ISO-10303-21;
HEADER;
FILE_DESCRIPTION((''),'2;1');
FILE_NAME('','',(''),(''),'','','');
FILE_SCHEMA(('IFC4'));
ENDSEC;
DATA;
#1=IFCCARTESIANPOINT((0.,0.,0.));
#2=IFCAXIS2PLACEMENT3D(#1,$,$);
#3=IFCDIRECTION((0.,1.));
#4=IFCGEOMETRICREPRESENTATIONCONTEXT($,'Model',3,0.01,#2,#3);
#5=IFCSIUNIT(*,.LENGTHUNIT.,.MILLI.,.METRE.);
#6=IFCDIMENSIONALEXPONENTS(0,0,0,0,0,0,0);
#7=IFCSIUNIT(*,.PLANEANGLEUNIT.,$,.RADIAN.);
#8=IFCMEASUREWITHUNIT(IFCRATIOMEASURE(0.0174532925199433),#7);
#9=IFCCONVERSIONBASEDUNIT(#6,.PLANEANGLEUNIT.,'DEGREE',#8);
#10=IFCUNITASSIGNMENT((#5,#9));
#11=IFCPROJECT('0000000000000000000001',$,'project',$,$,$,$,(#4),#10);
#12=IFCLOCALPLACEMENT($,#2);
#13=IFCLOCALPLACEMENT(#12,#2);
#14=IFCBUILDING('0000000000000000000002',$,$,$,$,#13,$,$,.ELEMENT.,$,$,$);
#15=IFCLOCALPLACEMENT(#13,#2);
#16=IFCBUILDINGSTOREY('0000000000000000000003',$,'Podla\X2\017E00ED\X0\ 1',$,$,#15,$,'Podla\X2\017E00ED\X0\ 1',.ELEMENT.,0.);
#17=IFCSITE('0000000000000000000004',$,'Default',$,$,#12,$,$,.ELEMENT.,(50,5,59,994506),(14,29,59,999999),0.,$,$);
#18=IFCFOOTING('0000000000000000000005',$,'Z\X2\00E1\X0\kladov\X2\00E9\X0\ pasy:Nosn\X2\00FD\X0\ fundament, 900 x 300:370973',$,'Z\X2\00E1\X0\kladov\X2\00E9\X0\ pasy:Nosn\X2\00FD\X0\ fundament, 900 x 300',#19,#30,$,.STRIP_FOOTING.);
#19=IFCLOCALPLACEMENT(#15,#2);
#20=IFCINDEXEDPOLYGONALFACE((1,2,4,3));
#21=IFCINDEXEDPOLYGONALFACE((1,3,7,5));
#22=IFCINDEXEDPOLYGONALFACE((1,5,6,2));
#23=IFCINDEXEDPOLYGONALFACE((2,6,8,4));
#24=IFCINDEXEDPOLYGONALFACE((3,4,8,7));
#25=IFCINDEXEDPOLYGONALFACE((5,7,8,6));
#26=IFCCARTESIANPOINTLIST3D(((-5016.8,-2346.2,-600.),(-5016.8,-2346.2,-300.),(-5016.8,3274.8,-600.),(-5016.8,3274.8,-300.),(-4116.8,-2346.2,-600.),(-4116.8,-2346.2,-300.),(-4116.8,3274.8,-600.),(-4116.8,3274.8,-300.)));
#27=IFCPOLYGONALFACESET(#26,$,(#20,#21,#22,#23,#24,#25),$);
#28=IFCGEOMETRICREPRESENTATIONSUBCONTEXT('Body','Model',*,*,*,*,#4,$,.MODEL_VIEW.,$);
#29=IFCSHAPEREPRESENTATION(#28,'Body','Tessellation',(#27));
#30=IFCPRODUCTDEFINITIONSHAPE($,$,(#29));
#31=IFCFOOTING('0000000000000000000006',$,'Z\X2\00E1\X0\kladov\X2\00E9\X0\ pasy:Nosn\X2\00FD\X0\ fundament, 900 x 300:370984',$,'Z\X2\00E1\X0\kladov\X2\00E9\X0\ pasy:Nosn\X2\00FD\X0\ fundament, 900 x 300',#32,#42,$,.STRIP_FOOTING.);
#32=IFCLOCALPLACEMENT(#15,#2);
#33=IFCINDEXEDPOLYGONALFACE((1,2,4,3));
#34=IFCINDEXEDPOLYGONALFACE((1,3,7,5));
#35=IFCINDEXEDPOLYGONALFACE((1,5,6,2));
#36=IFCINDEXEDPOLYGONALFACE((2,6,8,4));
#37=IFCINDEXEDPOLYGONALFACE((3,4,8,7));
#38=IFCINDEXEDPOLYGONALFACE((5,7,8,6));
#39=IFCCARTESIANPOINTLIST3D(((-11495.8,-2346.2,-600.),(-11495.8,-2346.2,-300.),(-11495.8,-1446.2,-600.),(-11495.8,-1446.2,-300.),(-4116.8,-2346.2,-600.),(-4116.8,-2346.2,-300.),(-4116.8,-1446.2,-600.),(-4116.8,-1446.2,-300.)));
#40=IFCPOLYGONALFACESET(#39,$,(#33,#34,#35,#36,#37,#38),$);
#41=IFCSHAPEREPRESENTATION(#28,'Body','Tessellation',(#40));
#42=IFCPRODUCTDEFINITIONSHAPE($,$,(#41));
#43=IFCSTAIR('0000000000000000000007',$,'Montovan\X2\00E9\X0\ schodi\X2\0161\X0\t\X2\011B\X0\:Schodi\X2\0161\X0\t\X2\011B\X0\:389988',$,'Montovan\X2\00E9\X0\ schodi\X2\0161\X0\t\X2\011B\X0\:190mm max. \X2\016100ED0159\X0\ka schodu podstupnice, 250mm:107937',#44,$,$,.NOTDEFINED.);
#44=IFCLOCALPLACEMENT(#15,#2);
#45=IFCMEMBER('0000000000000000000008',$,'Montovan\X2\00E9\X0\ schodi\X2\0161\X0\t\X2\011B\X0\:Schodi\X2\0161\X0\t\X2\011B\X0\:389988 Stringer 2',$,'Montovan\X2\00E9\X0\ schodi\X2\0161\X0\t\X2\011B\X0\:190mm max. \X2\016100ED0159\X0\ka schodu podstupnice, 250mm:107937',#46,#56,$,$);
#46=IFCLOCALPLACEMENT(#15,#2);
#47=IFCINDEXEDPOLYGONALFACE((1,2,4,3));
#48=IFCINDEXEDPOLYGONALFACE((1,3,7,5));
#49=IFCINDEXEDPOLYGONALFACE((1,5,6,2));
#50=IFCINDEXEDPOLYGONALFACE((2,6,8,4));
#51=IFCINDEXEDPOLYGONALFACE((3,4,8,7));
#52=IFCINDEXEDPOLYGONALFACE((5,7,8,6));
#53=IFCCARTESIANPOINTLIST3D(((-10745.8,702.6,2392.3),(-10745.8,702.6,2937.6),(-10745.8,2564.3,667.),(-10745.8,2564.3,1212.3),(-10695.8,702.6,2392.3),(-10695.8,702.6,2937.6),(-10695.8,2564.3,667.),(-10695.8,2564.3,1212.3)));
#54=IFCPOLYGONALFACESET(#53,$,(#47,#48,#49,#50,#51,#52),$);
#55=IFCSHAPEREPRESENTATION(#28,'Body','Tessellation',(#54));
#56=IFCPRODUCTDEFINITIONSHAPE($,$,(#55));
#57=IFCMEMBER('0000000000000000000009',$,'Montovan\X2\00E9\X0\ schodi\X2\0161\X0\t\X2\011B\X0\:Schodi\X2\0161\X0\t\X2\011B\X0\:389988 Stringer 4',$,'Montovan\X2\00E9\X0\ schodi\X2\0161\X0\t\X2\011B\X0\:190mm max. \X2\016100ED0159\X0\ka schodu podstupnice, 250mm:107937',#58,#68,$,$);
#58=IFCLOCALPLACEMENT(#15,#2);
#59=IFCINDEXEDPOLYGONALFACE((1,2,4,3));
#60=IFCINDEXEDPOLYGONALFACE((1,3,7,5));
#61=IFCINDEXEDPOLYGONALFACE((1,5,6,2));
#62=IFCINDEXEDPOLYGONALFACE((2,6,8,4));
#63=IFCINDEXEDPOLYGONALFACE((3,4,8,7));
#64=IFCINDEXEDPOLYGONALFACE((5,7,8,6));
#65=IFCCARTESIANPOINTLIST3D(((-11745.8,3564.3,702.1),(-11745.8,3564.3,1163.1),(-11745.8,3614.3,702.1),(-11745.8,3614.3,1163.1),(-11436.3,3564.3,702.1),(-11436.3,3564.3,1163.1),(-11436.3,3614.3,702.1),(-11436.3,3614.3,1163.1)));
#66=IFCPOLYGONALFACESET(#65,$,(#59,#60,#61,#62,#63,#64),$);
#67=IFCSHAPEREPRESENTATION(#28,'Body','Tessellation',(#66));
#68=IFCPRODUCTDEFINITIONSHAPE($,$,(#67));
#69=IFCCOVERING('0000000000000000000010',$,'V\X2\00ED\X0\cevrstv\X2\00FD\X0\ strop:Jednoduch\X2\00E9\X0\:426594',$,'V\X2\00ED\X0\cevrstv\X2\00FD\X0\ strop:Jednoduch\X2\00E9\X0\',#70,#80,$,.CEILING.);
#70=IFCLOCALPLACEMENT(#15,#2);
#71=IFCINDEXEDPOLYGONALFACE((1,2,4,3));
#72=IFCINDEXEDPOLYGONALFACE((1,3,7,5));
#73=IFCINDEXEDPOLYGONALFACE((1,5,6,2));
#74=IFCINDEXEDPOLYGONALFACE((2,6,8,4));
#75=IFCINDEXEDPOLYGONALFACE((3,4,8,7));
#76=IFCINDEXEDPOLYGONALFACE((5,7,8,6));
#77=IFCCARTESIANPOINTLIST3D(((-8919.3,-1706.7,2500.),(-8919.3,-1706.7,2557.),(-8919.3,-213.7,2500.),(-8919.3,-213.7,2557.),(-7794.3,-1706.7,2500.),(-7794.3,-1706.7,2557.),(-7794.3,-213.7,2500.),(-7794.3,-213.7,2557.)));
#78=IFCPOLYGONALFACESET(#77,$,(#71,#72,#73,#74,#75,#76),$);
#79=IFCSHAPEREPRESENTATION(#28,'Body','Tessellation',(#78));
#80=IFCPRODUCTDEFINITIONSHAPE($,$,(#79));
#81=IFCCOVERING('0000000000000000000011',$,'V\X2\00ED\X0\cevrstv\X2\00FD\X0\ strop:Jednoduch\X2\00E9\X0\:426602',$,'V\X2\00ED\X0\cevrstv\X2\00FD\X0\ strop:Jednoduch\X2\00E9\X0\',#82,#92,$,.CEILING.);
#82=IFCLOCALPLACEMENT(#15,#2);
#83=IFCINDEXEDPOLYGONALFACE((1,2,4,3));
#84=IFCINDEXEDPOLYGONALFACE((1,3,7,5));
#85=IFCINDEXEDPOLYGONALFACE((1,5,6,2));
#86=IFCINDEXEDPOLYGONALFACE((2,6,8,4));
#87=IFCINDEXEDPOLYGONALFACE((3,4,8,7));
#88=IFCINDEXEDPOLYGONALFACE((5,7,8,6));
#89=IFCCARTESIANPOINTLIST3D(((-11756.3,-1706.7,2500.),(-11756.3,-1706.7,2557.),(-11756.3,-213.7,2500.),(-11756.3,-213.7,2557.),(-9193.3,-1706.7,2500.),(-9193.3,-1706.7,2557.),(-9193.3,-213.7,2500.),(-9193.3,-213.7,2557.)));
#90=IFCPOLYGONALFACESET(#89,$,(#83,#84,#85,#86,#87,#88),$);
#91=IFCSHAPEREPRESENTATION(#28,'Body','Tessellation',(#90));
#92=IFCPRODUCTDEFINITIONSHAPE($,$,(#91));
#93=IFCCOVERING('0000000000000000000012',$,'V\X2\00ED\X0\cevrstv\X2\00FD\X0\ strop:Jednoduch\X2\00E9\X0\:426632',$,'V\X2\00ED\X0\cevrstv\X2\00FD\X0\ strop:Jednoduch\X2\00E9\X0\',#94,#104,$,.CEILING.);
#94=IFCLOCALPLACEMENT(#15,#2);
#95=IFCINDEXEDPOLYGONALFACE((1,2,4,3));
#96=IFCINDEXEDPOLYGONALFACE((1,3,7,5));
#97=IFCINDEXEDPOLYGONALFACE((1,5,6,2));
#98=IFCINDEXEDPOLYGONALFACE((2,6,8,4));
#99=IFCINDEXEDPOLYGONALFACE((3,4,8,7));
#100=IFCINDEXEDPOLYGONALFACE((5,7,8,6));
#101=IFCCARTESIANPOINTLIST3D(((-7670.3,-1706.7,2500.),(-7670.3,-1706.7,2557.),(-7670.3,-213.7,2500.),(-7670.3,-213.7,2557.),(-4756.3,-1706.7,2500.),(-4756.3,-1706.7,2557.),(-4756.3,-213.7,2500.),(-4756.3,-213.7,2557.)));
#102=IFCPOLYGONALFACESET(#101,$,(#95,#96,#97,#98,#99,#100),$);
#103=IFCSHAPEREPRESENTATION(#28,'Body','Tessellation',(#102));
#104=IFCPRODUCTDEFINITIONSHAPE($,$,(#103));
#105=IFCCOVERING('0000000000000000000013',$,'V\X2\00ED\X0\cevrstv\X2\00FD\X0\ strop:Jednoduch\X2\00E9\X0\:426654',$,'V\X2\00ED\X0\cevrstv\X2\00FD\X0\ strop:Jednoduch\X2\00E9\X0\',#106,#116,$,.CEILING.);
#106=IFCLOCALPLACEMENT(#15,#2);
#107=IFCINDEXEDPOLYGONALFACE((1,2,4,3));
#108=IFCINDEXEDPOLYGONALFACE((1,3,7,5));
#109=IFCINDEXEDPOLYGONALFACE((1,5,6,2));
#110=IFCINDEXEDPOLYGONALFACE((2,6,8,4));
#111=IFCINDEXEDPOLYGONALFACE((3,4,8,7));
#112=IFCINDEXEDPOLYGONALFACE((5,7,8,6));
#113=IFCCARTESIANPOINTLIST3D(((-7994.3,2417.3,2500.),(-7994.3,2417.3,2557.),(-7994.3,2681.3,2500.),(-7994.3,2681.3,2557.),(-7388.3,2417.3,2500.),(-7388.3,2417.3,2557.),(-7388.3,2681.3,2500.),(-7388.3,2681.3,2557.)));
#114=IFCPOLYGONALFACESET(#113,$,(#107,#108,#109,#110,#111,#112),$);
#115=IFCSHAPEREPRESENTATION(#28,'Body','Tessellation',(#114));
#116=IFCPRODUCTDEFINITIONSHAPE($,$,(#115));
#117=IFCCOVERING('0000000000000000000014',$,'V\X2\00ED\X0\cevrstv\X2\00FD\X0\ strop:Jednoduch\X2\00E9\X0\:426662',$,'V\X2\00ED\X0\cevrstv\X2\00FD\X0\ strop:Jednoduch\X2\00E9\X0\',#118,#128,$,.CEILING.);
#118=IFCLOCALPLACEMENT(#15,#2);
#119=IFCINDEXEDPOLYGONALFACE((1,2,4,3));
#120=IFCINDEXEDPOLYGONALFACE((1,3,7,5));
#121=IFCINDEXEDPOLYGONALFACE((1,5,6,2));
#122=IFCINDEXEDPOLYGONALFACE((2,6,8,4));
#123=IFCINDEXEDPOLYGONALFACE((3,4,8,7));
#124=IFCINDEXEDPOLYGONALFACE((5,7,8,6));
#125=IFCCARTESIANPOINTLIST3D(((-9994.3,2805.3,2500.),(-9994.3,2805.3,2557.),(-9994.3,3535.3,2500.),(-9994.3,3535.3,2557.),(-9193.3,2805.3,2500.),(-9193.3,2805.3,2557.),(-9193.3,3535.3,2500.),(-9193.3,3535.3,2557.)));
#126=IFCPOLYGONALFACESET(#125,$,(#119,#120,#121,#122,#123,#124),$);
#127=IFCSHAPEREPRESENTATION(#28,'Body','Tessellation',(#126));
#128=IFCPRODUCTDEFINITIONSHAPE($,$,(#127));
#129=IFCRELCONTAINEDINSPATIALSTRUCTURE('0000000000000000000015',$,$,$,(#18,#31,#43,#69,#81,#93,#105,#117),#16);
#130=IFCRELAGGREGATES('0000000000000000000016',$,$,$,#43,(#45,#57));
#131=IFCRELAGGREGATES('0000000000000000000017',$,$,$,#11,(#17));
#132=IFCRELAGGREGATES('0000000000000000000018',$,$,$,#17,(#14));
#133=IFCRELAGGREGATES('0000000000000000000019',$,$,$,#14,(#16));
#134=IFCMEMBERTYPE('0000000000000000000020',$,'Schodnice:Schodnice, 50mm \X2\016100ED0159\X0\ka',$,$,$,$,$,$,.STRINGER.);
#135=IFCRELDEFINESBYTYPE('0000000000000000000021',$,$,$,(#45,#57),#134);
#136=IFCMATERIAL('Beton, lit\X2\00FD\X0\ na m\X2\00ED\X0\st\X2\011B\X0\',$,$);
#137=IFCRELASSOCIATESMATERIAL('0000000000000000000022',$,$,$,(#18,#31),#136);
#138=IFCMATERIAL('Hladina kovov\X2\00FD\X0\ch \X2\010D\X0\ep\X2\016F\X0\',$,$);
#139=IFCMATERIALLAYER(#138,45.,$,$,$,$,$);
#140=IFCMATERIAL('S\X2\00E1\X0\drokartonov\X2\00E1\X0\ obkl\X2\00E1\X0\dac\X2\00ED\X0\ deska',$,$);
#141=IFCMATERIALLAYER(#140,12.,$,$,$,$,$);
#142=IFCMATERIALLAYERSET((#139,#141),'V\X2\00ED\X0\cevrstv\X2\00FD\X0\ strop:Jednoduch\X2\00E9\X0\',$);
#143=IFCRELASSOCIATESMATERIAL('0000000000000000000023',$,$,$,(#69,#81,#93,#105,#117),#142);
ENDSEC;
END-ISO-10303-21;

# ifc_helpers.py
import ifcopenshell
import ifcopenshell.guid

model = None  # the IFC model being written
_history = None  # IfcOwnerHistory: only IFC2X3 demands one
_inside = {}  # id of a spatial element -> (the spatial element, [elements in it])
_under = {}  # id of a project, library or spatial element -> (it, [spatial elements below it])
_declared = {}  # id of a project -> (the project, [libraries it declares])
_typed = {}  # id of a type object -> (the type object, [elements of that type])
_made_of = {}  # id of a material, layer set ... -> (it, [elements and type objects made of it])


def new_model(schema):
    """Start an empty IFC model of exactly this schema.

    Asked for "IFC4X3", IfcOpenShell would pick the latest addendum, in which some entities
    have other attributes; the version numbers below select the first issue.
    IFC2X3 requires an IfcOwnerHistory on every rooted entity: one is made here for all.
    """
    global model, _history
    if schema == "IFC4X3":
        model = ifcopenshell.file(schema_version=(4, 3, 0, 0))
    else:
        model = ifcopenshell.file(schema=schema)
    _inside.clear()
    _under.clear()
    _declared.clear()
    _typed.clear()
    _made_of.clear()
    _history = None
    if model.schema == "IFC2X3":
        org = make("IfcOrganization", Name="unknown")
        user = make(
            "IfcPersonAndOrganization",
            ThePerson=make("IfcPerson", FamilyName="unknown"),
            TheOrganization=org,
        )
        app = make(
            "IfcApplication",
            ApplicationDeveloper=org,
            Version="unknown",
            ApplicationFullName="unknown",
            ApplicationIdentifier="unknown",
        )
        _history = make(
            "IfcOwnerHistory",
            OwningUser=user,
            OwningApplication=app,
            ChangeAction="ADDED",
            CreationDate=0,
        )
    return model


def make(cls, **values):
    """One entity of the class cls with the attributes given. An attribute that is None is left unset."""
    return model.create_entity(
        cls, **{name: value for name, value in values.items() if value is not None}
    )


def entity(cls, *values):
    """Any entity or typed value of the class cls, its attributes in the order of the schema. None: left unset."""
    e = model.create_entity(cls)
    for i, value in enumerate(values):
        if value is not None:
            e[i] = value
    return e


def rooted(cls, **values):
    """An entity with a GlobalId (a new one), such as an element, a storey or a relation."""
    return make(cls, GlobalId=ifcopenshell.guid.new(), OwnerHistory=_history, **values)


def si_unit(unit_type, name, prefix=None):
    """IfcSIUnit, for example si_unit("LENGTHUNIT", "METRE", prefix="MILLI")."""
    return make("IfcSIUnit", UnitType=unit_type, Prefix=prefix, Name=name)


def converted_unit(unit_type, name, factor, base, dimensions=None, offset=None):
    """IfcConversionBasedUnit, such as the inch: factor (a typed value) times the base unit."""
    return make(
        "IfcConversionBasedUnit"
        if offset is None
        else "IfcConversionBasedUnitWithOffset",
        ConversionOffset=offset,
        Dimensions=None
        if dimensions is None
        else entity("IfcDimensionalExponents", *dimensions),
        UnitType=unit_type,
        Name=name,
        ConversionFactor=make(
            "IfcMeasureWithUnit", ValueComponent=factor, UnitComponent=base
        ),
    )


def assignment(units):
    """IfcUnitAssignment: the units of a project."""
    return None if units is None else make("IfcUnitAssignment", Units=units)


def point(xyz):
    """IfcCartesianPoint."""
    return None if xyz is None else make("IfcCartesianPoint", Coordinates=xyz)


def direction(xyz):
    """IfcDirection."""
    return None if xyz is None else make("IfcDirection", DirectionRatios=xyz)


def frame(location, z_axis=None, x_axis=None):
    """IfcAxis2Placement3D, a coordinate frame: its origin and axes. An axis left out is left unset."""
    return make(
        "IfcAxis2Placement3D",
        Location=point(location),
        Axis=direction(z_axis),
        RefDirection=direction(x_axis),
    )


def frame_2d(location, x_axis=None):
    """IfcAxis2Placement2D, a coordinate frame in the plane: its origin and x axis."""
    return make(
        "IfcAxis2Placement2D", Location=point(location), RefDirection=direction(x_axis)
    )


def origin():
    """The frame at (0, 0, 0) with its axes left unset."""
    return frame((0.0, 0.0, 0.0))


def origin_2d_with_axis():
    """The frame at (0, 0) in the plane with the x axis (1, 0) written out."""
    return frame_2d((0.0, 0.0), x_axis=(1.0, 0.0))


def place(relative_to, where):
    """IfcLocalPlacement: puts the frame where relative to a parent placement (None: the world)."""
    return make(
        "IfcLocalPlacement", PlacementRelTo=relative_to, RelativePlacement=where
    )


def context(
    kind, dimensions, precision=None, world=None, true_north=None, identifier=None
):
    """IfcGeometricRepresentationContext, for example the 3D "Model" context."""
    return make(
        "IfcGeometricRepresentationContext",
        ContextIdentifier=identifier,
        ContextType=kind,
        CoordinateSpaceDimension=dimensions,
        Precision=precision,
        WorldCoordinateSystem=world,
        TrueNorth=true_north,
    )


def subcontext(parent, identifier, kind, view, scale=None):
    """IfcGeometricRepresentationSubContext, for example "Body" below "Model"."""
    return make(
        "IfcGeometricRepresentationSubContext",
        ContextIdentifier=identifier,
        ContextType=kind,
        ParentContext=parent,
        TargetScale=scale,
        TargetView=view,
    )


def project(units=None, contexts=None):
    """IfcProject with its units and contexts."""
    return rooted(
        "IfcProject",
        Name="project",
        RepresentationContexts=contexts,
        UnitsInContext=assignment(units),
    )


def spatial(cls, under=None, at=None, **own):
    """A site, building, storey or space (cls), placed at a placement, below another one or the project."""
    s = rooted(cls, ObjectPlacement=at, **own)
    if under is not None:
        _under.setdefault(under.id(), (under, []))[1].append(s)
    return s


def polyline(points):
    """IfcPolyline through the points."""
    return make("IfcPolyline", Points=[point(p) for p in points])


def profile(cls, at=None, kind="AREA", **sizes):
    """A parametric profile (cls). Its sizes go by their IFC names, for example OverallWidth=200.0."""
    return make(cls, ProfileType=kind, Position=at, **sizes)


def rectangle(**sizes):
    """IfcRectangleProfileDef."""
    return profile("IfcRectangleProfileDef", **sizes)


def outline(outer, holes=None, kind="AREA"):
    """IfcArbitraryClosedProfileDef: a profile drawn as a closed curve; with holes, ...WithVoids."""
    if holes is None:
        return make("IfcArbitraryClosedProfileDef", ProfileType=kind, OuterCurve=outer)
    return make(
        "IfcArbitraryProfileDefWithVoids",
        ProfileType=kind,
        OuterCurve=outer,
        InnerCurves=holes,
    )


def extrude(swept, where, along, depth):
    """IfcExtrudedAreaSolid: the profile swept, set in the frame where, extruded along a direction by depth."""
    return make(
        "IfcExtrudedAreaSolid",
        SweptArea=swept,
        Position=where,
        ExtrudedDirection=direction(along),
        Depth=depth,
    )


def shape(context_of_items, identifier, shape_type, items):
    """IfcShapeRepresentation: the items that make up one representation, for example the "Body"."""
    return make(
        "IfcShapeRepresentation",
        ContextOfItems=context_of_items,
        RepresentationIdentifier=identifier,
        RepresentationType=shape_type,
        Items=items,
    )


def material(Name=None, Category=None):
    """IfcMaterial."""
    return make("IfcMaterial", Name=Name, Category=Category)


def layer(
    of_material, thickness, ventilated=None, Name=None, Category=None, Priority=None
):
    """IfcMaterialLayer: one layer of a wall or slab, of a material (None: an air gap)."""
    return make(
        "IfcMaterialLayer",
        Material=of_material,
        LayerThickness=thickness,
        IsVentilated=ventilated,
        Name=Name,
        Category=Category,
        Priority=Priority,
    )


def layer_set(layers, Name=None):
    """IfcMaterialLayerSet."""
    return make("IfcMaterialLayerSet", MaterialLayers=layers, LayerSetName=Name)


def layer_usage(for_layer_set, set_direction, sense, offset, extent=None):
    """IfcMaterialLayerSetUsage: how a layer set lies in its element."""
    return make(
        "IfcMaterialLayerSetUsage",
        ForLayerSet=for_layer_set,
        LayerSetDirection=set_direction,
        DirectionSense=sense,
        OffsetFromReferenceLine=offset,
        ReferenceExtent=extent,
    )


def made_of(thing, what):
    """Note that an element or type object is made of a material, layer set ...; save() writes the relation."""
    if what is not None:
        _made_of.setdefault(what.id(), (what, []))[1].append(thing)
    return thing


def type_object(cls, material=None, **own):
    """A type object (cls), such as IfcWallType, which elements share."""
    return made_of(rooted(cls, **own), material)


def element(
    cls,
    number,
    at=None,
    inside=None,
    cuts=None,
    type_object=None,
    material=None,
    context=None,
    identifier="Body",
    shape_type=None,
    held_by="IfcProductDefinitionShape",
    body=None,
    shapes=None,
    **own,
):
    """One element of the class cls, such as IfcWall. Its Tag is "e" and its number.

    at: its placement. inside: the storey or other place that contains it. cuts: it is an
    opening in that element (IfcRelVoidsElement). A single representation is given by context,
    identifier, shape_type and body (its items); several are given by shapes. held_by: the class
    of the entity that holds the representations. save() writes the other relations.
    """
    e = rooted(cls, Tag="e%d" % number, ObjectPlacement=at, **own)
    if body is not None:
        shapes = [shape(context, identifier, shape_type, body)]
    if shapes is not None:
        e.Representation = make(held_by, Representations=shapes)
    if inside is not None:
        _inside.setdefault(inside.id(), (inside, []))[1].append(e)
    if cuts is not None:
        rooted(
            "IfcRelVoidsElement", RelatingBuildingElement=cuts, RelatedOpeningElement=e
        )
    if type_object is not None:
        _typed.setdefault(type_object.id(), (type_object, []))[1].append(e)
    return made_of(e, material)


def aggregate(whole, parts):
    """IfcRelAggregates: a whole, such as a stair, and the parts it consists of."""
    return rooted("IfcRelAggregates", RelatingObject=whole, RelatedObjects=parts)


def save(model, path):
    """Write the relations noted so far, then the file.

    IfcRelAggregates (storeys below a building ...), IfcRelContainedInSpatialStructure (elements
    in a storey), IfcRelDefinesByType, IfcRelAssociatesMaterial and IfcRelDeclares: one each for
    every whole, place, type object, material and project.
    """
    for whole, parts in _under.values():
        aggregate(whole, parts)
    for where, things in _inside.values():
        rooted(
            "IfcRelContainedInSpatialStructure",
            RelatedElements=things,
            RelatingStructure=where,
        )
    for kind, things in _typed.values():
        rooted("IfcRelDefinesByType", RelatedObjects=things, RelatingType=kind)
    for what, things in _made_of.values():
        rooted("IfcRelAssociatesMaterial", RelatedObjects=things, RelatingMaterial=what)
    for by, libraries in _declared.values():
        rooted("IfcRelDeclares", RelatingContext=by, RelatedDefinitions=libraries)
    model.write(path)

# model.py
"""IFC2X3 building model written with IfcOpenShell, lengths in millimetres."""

from ifc_helpers import new_model, entity, si_unit, converted_unit, direction, frame, frame_2d, origin, origin_2d_with_axis, place, context, subcontext, project, spatial, polyline, rectangle, outline, extrude, material, layer, layer_set, layer_usage, type_object, element, aggregate, save


model = new_model("IFC2X3")

# Units and contexts
model_context = context("Model", 3, precision=0.01, world=origin(), true_north=direction((0.0, 1.0)))
body_context = subcontext(model_context, "Body", "Model", "MODEL_VIEW")
ifc_project = project(units=[si_unit("LENGTHUNIT", "METRE", prefix="MILLI"), converted_unit("PLANEANGLEUNIT", "DEGREE", entity("IfcRatioMeasure", 0.0174532925199433), si_unit("PLANEANGLEUNIT", "RADIAN"), dimensions=[0, 0, 0, 0, 0, 0, 0])], contexts=[model_context])

# Site, building, storey
site_placement = place(None, origin())
site = spatial("IfcSite", under=ifc_project, at=site_placement, Name="Default", CompositionType="ELEMENT", RefLatitude=(50, 5, 59, 994506), RefLongitude=(14, 29, 59, 999999), RefElevation=0.0)
building_placement = place(site_placement, origin())
building = spatial("IfcBuilding", under=site, at=building_placement, CompositionType="ELEMENT")
storey_placement = place(building_placement, origin())
storey = spatial("IfcBuildingStorey", under=building, at=storey_placement, Name="Podlaží 1", LongName="Podlaží 1", CompositionType="ELEMENT", Elevation=0.0)

# Footings
ifc_material_1 = material(Name="Beton, litý na místě")
footing_1_placement = place(storey_placement, origin())
element("IfcFooting", 1, at=footing_1_placement, inside=storey, material=ifc_material_1, Name="Základové pasy:Nosný fundament, 900 x 300:370973", ObjectType="Základové pasy:Nosný fundament, 900 x 300", PredefinedType="STRIP_FOOTING", context=body_context, shape_type="SweptSolid", body=[
    extrude(rectangle(XDim=5621.0, YDim=900.0, at=frame_2d((0.0, 0.0), x_axis=(1.0, 0.0))), frame((-4566.8, 464.3, -600.0), z_axis=(0.0, 0.0, 1.0), x_axis=(0.0, 1.0, 0.0)), (0.0, 0.0, 1.0), 300.0),
])
footing_2_placement = place(storey_placement, origin())
element("IfcFooting", 2, at=footing_2_placement, inside=storey, material=ifc_material_1, Name="Základové pasy:Nosný fundament, 900 x 300:370984", ObjectType="Základové pasy:Nosný fundament, 900 x 300", PredefinedType="STRIP_FOOTING", context=body_context, shape_type="SweptSolid", body=[
    extrude(rectangle(XDim=7379.0, YDim=900.0, at=origin_2d_with_axis()), frame((-7806.3, -1896.2, -600.0), z_axis=(0.0, 0.0, 1.0), x_axis=(-1.0, 0.0, 0.0)), (0.0, 0.0, 1.0), 300.0),
])

# Stair, members
stair_placement = place(storey_placement, origin())
stair = element("IfcStair", 3, at=stair_placement, inside=storey, Name="Montované schodiště:Schodiště:389988", ObjectType="Montované schodiště:190mm max. šířka schodu podstupnice, 250mm:107937", ShapeType="NOTDEFINED")
member_type = type_object("IfcMemberType", Name="Schodnice:Schodnice, 50mm šířka", PredefinedType="STRINGER")
member_1_placement = place(stair_placement, origin())
member_1 = element("IfcMember", 4, at=member_1_placement, type_object=member_type, Name="Montované schodiště:Schodiště:389988 Stringer 2", ObjectType="Montované schodiště:190mm max. šířka schodu podstupnice, 250mm:107937", context=body_context, shape_type="SweptSolid", body=[
    extrude(outline(polyline([(-1083.7, -200.0), (1454.4, -200.0), (1083.7, 200.0), (-1454.4, 200.0), (-1083.7, -200.0)])), frame((-10745.8, 1633.5, 1802.3), z_axis=(1.0, 0.0, 0.0), x_axis=(0.0, -0.733468, 0.679724)), (0.0, 0.0, 1.0), 50.0),
])
member_2_placement = place(stair_placement, origin())
member_2 = element("IfcMember", 5, at=member_2_placement, type_object=member_type, Name="Montované schodiště:Schodiště:389988 Stringer 4", ObjectType="Montované schodiště:190mm max. šířka schodu podstupnice, 250mm:107937", context=body_context, shape_type="SweptSolid", body=[
    extrude(rectangle(XDim=309.4, YDim=50.0, at=frame_2d((0.0, 0.0), x_axis=(1.0, 0.0))), frame((-11591.0, 3589.3, 702.1), z_axis=(0.0, 0.0, 1.0), x_axis=(-1.0, 0.0, 0.0)), (0.0, 0.0, 1.0), 461.0),
])
aggregate(stair, [member_1, member_2])

# Coverings
ifc_material_2 = material(Name="Hladina kovových čepů")
ifc_layer_1 = layer(ifc_material_2, 45.0)
ifc_material_3 = material(Name="Sádrokartonová obkládací deska")
ifc_layer_2 = layer(ifc_material_3, 12.0)
ifc_layer_set = layer_set([ifc_layer_1, ifc_layer_2], Name="Vícevrstvý strop:Jednoduché")
ifc_layer_usage_1 = layer_usage(ifc_layer_set, "AXIS3", "NEGATIVE", 0.0)
covering_1_placement = place(storey_placement, origin())
element("IfcCovering", 6, at=covering_1_placement, inside=storey, material=ifc_layer_usage_1, Name="Vícevrstvý strop:Jednoduché:426594", ObjectType="Vícevrstvý strop:Jednoduché", PredefinedType="CEILING", context=body_context, shape_type="SweptSolid", body=[
    extrude(rectangle(XDim=1125.0, YDim=1493.0, at=frame_2d((0.0, 0.0), x_axis=(1.0, 0.0))), frame((-8356.8, -960.2, 2500.0), z_axis=(0.0, 0.0, 1.0), x_axis=(-1.0, 0.0, 0.0)), (0.0, 0.0, 1.0), 57.0),
])
ifc_layer_usage_2 = layer_usage(ifc_layer_set, "AXIS3", "NEGATIVE", 0.0)
covering_2_placement = place(storey_placement, origin())
element("IfcCovering", 7, at=covering_2_placement, inside=storey, material=ifc_layer_usage_2, Name="Vícevrstvý strop:Jednoduché:426602", ObjectType="Vícevrstvý strop:Jednoduché", PredefinedType="CEILING", context=body_context, shape_type="SweptSolid", body=[
    extrude(rectangle(XDim=1493.0, YDim=2563.0, at=frame_2d((0.0, 0.0), x_axis=(1.0, 0.0))), frame((-10474.8, -960.2, 2500.0), z_axis=(0.0, 0.0, 1.0), x_axis=(0.0, 1.0, 0.0)), (0.0, 0.0, 1.0), 57.0),
])
ifc_layer_usage_3 = layer_usage(ifc_layer_set, "AXIS3", "NEGATIVE", 0.0)
covering_3_placement = place(storey_placement, origin())
element("IfcCovering", 8, at=covering_3_placement, inside=storey, material=ifc_layer_usage_3, Name="Vícevrstvý strop:Jednoduché:426632", ObjectType="Vícevrstvý strop:Jednoduché", PredefinedType="CEILING", context=body_context, shape_type="SweptSolid", body=[
    extrude(rectangle(XDim=2914.0, YDim=1493.0, at=frame_2d((0.0, 0.0), x_axis=(1.0, 0.0))), frame((-6213.3, -960.2, 2500.0), z_axis=(0.0, 0.0, 1.0), x_axis=(-1.0, 0.0, 0.0)), (0.0, 0.0, 1.0), 57.0),
])
ifc_layer_usage_4 = layer_usage(ifc_layer_set, "AXIS3", "NEGATIVE", 0.0)
covering_4_placement = place(storey_placement, origin())
element("IfcCovering", 9, at=covering_4_placement, inside=storey, material=ifc_layer_usage_4, Name="Vícevrstvý strop:Jednoduché:426654", ObjectType="Vícevrstvý strop:Jednoduché", PredefinedType="CEILING", context=body_context, shape_type="SweptSolid", body=[
    extrude(rectangle(XDim=264.0, YDim=606.0, at=frame_2d((0.0, 0.0), x_axis=(1.0, 0.0))), frame((-7691.3, 2549.3, 2500.0), z_axis=(0.0, 0.0, 1.0), x_axis=(0.0, 1.0, 0.0)), (0.0, 0.0, 1.0), 57.0),
])
ifc_layer_usage_5 = layer_usage(ifc_layer_set, "AXIS3", "NEGATIVE", 0.0)
covering_5_placement = place(storey_placement, origin())
element("IfcCovering", 10, at=covering_5_placement, inside=storey, material=ifc_layer_usage_5, Name="Vícevrstvý strop:Jednoduché:426662", ObjectType="Vícevrstvý strop:Jednoduché", PredefinedType="CEILING", context=body_context, shape_type="SweptSolid", body=[
    extrude(rectangle(XDim=730.0, YDim=801.0, at=frame_2d((0.0, 0.0), x_axis=(1.0, 0.0))), frame((-9593.8, 3170.3, 2500.0), z_axis=(0.0, 0.0, 1.0), x_axis=(0.0, -1.0, 0.0)), (0.0, 0.0, 1.0), 57.0),
])

save(model, "model.ifc")
